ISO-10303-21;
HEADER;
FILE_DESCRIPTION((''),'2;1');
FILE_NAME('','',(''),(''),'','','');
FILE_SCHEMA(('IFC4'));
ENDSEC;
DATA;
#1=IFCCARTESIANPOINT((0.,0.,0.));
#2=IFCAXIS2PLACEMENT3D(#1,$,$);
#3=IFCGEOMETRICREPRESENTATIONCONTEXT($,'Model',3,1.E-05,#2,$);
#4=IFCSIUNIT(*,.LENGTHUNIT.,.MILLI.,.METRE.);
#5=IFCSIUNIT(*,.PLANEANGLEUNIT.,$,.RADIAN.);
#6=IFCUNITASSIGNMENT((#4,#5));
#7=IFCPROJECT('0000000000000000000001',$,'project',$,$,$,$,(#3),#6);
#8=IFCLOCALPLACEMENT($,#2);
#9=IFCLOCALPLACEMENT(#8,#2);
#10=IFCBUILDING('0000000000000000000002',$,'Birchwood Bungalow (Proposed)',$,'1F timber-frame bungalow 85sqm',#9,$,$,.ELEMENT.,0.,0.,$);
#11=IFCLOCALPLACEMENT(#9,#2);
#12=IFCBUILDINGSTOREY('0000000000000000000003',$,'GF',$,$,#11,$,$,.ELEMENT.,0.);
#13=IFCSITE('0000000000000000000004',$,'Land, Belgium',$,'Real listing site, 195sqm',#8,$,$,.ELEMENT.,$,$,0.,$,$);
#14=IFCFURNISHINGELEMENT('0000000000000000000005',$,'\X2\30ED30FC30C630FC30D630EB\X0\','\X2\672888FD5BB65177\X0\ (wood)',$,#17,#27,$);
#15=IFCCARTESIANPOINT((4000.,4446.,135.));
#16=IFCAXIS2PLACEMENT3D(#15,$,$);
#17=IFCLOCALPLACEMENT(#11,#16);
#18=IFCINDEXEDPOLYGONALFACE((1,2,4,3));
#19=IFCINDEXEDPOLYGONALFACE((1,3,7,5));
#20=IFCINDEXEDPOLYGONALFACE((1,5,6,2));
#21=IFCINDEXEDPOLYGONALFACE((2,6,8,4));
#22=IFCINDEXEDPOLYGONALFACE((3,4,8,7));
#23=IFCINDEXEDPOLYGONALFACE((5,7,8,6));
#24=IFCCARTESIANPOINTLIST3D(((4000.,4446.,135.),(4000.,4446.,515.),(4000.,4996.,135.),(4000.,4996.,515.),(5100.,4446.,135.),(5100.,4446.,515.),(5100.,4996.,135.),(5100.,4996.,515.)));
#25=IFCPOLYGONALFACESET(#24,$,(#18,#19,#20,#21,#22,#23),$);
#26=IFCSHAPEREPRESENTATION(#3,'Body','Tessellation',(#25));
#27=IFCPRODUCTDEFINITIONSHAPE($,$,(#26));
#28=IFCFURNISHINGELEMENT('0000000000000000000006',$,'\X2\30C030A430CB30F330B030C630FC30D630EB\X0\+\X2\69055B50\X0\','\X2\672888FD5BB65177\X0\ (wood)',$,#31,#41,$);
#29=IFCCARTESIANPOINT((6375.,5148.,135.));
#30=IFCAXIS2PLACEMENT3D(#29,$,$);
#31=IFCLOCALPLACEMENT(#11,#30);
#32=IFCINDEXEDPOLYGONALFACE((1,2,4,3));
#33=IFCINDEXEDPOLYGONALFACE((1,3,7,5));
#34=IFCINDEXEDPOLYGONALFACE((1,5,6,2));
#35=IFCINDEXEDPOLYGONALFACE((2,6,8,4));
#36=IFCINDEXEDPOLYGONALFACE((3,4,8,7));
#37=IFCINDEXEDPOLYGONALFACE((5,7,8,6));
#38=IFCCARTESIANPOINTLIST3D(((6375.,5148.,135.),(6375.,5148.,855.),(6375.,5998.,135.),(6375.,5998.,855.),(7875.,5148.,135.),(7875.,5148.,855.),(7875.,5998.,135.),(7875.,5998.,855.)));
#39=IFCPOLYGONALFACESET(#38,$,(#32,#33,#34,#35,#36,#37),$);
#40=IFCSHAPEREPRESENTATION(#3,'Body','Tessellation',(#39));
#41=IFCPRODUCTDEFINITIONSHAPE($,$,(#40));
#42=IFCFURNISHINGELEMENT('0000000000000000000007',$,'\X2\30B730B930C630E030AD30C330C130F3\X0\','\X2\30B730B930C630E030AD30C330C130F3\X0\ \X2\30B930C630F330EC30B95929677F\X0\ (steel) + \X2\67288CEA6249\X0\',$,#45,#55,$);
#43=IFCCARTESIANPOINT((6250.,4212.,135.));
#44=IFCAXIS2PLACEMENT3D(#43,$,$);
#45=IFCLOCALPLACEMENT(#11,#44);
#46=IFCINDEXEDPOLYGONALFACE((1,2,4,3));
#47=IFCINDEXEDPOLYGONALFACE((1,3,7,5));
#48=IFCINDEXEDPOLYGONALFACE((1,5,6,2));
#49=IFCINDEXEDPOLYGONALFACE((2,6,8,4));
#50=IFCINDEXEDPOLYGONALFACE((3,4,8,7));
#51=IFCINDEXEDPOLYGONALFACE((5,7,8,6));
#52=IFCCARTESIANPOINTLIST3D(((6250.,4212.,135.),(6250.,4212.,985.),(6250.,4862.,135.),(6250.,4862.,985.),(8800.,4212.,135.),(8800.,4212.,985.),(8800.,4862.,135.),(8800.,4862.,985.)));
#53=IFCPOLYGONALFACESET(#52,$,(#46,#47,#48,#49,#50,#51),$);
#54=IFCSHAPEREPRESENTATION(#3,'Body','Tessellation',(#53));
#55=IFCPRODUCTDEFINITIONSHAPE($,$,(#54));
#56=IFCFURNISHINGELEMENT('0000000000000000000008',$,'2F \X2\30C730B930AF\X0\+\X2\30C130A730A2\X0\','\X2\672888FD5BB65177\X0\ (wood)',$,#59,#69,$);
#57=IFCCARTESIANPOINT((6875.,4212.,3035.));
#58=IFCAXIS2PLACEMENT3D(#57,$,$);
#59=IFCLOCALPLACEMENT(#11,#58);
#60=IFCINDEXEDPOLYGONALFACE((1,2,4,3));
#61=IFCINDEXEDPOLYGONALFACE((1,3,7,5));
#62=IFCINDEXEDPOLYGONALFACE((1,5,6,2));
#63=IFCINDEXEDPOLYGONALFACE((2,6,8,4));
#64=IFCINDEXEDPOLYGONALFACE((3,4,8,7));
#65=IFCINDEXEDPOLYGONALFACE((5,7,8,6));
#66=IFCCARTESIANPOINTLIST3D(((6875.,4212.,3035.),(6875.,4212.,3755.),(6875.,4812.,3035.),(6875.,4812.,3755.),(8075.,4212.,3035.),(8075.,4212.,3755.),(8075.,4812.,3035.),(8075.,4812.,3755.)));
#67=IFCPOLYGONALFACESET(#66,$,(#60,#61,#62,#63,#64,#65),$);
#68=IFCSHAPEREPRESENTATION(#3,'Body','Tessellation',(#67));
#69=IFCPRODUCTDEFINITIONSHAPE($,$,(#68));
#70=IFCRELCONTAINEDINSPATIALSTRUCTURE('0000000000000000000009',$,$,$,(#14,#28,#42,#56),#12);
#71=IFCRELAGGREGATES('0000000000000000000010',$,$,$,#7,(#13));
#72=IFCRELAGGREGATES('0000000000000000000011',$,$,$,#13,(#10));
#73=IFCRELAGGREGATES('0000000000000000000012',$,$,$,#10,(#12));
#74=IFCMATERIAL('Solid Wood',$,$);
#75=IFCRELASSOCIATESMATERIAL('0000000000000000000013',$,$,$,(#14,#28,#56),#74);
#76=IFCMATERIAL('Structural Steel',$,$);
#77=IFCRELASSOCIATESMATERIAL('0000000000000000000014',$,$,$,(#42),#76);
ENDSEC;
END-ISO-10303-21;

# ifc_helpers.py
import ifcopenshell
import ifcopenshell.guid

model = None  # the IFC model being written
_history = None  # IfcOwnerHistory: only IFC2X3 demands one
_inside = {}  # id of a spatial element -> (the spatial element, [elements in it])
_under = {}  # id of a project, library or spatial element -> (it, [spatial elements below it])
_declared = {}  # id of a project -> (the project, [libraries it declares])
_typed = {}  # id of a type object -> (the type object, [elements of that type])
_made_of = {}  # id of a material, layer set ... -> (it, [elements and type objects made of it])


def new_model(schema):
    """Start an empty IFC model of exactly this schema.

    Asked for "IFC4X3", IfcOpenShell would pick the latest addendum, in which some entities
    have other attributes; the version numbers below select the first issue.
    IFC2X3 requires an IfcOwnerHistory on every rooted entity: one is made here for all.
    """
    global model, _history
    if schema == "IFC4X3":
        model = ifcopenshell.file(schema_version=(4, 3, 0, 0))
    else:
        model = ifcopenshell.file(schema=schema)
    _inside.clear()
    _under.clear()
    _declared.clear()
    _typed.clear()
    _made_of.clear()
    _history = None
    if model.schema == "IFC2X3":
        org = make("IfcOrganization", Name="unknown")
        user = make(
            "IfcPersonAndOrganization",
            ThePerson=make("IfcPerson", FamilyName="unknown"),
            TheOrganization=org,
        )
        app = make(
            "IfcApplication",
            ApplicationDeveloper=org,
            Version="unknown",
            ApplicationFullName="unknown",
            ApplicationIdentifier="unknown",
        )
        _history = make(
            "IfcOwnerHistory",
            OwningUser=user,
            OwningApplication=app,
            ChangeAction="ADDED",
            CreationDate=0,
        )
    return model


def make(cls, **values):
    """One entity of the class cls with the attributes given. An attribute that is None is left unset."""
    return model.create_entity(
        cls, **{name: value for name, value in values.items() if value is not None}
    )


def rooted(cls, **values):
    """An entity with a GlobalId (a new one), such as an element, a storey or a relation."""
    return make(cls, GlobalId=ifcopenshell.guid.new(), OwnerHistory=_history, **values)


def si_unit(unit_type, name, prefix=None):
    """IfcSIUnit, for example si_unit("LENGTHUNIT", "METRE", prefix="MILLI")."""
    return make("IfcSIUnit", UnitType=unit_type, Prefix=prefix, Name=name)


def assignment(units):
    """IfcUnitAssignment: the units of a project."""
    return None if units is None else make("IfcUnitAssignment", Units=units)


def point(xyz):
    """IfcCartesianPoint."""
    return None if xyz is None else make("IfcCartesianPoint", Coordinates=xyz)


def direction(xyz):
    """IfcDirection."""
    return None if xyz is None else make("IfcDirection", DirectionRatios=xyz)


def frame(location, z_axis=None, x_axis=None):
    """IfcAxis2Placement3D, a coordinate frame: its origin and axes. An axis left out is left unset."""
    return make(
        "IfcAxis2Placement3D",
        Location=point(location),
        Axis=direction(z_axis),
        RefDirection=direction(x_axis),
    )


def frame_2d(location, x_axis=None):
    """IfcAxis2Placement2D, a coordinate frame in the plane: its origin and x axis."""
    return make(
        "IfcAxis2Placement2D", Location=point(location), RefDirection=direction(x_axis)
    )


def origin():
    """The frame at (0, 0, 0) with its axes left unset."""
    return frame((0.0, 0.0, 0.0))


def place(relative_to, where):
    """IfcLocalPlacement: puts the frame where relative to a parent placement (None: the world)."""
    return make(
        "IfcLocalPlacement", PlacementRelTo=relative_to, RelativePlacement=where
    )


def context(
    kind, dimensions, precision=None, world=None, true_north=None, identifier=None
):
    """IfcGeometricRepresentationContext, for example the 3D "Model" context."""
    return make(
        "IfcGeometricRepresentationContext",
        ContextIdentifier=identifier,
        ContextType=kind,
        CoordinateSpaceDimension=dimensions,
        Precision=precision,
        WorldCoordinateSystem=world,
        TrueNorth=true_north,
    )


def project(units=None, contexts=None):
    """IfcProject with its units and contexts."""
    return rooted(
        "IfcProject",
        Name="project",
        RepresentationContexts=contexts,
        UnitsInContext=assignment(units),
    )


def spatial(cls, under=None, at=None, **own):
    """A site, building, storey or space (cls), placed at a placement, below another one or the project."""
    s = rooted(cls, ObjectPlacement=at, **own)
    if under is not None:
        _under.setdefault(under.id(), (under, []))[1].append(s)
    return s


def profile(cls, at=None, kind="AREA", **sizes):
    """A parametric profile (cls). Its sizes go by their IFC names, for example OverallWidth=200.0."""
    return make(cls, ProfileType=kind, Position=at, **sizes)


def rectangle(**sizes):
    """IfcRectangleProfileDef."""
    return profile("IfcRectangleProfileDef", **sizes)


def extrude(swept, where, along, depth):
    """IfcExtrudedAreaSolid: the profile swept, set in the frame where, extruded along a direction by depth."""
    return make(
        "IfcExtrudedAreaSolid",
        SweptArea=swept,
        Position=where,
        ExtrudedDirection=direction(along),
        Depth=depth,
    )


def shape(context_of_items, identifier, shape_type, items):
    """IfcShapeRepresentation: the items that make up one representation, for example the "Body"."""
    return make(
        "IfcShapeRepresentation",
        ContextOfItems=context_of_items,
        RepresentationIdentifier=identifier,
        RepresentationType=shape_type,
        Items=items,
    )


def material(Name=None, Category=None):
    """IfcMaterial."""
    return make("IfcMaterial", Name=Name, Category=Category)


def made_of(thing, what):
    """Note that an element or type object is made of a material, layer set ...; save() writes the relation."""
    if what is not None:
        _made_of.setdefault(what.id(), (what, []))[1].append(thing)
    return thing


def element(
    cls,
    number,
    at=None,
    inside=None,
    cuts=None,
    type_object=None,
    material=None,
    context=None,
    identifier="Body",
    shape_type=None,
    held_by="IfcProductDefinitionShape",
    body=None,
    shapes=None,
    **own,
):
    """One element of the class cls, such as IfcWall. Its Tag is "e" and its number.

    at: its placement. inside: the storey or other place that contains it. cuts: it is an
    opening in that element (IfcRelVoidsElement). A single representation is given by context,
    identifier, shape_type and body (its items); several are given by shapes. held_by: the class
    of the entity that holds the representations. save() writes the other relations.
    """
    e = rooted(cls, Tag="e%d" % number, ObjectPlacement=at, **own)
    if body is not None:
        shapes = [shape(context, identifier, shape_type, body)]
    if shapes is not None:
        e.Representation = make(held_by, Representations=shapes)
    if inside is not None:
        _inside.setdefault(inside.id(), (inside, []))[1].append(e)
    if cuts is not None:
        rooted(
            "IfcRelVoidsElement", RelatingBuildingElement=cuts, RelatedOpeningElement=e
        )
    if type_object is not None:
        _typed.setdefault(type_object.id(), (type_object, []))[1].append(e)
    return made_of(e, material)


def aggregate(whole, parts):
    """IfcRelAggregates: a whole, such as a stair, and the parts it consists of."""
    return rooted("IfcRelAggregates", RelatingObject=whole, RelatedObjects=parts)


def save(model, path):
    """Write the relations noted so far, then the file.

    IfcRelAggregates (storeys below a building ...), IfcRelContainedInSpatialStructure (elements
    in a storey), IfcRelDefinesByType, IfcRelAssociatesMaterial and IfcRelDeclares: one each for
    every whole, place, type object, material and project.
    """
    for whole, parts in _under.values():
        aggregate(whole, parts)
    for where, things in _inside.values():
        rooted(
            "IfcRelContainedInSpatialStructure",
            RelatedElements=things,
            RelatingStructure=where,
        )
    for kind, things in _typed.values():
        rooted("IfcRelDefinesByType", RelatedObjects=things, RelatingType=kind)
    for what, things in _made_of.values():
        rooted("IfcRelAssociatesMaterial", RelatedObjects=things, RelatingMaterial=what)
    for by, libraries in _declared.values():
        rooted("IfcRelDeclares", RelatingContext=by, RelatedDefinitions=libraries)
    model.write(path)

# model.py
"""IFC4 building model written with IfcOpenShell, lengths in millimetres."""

from ifc_helpers import new_model, si_unit, frame, frame_2d, origin, place, context, project, spatial, rectangle, extrude, material, element, save


model = new_model("IFC4")

# Units and contexts
model_context = context("Model", 3, precision=1e-05, world=origin())
ifc_project = project(units=[si_unit("LENGTHUNIT", "METRE", prefix="MILLI"), si_unit("PLANEANGLEUNIT", "RADIAN")], contexts=[model_context])

# Site, building, storey
site_placement = place(None, origin())
site = spatial("IfcSite", under=ifc_project, at=site_placement, Name="Land, Belgium", ObjectType="Real listing site, 195sqm", CompositionType="ELEMENT", RefElevation=0.0)
building_placement = place(site_placement, origin())
building = spatial("IfcBuilding", under=site, at=building_placement, Name="Birchwood Bungalow (Proposed)", ObjectType="1F timber-frame bungalow 85sqm", CompositionType="ELEMENT", ElevationOfRefHeight=0.0, ElevationOfTerrain=0.0)
storey_placement = place(building_placement, origin())
storey = spatial("IfcBuildingStorey", under=building, at=storey_placement, Name="GF", CompositionType="ELEMENT", Elevation=0.0)

# Shared definitions
ifc_material_1 = material(Name="Solid Wood")

# Shared definitions
ifc_material_2 = material(Name="Structural Steel")

# Furnishing elements
furnishing_1_placement = place(storey_placement, frame((4000.0, 4446.0, 135.0)))
element("IfcFurnishingElement", 1, at=furnishing_1_placement, inside=storey, material=ifc_material_1, Name="ローテーブル", Description="木製家具 (wood)", context=model_context, shape_type="SweptSolid", body=[
    extrude(rectangle(XDim=1100.0, YDim=550.0, at=frame_2d((550.0, 275.0))), frame((4000.0, 4446.0, 135.0)), (0.0, 0.0, 1.0), 380.0),
])
furnishing_2_placement = place(storey_placement, frame((6375.0, 5148.0, 135.0)))
element("IfcFurnishingElement", 2, at=furnishing_2_placement, inside=storey, material=ifc_material_1, Name="ダイニングテーブル+椅子", Description="木製家具 (wood)", context=model_context, shape_type="SweptSolid", body=[
    extrude(rectangle(XDim=1500.0, YDim=850.0, at=frame_2d((750.0, 425.0))), frame((6375.0, 5148.0, 135.0)), (0.0, 0.0, 1.0), 720.0),
])
furnishing_3_placement = place(storey_placement, frame((6250.0, 4212.0, 135.0)))
element("IfcFurnishingElement", 3, at=furnishing_3_placement, inside=storey, material=ifc_material_2, Name="システムキッチン", Description="システムキッチン ステンレス天板 (steel) + 木質扉", context=model_context, shape_type="SweptSolid", body=[
    extrude(rectangle(XDim=2550.0, YDim=650.0, at=frame_2d((1275.0, 325.0))), frame((6250.0, 4212.0, 135.0)), (0.0, 0.0, 1.0), 850.0),
])
furnishing_4_placement = place(storey_placement, frame((6875.0, 4212.0, 3035.0)))
element("IfcFurnishingElement", 4, at=furnishing_4_placement, inside=storey, material=ifc_material_1, Name="2F デスク+チェア", Description="木製家具 (wood)", context=model_context, shape_type="SweptSolid", body=[
    extrude(rectangle(XDim=1200.0, YDim=600.0, at=frame_2d((600.0, 300.0))), frame((6875.0, 4212.0, 3035.0)), (0.0, 0.0, 1.0), 720.0),
])

save(model, "model.ifc")
